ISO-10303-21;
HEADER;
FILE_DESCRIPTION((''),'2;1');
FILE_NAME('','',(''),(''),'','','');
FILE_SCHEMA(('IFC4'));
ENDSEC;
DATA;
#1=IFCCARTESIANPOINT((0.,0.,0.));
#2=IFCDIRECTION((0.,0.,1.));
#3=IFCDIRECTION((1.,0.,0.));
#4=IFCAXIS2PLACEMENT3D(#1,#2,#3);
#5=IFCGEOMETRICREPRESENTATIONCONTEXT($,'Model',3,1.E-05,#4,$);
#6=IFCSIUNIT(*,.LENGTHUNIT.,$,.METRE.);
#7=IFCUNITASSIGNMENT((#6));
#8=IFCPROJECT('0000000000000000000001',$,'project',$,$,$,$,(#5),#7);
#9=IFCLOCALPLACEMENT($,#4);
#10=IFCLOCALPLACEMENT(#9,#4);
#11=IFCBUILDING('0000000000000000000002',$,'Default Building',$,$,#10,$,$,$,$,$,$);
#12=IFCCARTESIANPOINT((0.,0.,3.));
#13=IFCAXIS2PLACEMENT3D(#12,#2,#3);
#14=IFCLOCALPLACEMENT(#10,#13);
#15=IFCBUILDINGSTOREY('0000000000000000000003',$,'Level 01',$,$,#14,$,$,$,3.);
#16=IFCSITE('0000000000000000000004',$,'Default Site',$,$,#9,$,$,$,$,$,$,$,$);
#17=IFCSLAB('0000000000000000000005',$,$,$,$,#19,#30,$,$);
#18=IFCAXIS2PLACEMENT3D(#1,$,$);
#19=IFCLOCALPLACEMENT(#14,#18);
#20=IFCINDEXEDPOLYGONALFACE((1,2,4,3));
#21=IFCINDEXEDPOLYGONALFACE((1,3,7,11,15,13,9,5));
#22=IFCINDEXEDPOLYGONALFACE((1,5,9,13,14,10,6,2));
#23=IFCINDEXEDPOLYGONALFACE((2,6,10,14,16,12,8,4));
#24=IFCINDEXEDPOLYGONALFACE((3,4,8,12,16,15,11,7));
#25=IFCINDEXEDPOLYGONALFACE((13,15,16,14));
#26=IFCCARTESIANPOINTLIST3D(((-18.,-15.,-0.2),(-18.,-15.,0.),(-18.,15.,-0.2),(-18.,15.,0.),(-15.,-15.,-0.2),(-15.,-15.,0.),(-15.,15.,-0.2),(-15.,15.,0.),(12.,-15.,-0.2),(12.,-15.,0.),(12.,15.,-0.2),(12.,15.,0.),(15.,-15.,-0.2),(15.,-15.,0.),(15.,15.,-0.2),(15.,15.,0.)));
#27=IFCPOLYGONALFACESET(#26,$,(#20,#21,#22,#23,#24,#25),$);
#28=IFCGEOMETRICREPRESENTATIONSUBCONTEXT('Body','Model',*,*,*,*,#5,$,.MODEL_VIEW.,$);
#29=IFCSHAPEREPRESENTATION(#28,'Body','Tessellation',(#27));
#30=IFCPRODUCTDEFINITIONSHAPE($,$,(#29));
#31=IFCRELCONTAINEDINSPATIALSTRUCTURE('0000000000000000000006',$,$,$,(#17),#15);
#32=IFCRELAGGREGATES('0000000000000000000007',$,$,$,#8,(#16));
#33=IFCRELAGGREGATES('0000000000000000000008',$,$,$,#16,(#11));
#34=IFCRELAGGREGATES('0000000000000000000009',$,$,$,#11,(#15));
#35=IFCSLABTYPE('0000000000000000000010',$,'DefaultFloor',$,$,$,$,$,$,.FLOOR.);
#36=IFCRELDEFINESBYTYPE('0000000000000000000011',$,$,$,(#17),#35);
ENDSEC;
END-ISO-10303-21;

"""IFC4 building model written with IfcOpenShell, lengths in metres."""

from ifc_helpers import new_model, si_unit, frame, origin_with_axes, place, context, subcontext, project, spatial, polyline, outline, extrude, type_object, element, save


model = new_model("IFC4")

# Units and contexts
model_context = context("Model", 3, precision=1e-05, world=origin_with_axes())
body_context = subcontext(model_context, "Body", "Model", "MODEL_VIEW")
ifc_project = project(units=[si_unit("LENGTHUNIT", "METRE")], contexts=[model_context])

# Site, building, storey
site_placement = place(None, origin_with_axes())
site = spatial("IfcSite", under=ifc_project, at=site_placement, Name="Default Site")
building_placement = place(site_placement, origin_with_axes())
building = spatial("IfcBuilding", under=site, at=building_placement, Name="Default Building")
storey_placement = place(building_placement, frame((0.0, 0.0, 3.0), z_axis=(0.0, 0.0, 1.0), x_axis=(1.0, 0.0, 0.0)))
storey = spatial("IfcBuildingStorey", under=building, at=storey_placement, Name="Level 01", Elevation=3.0)

# Slab
slab_type = type_object("IfcSlabType", Name="DefaultFloor", PredefinedType="FLOOR")
slab_placement = place(storey_placement, frame((0.0, 0.0, -3.0), z_axis=(0.0, 0.0, 1.0), x_axis=(1.0, 0.0, 0.0)))
element("IfcSlab", 1, at=slab_placement, inside=storey, type_object=slab_type, context=body_context, shape_type="SweptSolid", body=[
    extrude(outline(polyline([(-18.0, 15.0), (-15.0, 15.0), (12.0, 15.0), (15.0, 15.0), (15.0, -15.0), (12.0, -15.0), (-15.0, -15.0), (-18.0, -15.0), (-18.0, 15.0)])), frame((0.0, 0.0, 3.0), z_axis=(0.0, 0.0, 1.0), x_axis=(1.0, 0.0, 0.0)), (0.0, 0.0, -1.0), 0.2),
])

save(model, "model.ifc")
